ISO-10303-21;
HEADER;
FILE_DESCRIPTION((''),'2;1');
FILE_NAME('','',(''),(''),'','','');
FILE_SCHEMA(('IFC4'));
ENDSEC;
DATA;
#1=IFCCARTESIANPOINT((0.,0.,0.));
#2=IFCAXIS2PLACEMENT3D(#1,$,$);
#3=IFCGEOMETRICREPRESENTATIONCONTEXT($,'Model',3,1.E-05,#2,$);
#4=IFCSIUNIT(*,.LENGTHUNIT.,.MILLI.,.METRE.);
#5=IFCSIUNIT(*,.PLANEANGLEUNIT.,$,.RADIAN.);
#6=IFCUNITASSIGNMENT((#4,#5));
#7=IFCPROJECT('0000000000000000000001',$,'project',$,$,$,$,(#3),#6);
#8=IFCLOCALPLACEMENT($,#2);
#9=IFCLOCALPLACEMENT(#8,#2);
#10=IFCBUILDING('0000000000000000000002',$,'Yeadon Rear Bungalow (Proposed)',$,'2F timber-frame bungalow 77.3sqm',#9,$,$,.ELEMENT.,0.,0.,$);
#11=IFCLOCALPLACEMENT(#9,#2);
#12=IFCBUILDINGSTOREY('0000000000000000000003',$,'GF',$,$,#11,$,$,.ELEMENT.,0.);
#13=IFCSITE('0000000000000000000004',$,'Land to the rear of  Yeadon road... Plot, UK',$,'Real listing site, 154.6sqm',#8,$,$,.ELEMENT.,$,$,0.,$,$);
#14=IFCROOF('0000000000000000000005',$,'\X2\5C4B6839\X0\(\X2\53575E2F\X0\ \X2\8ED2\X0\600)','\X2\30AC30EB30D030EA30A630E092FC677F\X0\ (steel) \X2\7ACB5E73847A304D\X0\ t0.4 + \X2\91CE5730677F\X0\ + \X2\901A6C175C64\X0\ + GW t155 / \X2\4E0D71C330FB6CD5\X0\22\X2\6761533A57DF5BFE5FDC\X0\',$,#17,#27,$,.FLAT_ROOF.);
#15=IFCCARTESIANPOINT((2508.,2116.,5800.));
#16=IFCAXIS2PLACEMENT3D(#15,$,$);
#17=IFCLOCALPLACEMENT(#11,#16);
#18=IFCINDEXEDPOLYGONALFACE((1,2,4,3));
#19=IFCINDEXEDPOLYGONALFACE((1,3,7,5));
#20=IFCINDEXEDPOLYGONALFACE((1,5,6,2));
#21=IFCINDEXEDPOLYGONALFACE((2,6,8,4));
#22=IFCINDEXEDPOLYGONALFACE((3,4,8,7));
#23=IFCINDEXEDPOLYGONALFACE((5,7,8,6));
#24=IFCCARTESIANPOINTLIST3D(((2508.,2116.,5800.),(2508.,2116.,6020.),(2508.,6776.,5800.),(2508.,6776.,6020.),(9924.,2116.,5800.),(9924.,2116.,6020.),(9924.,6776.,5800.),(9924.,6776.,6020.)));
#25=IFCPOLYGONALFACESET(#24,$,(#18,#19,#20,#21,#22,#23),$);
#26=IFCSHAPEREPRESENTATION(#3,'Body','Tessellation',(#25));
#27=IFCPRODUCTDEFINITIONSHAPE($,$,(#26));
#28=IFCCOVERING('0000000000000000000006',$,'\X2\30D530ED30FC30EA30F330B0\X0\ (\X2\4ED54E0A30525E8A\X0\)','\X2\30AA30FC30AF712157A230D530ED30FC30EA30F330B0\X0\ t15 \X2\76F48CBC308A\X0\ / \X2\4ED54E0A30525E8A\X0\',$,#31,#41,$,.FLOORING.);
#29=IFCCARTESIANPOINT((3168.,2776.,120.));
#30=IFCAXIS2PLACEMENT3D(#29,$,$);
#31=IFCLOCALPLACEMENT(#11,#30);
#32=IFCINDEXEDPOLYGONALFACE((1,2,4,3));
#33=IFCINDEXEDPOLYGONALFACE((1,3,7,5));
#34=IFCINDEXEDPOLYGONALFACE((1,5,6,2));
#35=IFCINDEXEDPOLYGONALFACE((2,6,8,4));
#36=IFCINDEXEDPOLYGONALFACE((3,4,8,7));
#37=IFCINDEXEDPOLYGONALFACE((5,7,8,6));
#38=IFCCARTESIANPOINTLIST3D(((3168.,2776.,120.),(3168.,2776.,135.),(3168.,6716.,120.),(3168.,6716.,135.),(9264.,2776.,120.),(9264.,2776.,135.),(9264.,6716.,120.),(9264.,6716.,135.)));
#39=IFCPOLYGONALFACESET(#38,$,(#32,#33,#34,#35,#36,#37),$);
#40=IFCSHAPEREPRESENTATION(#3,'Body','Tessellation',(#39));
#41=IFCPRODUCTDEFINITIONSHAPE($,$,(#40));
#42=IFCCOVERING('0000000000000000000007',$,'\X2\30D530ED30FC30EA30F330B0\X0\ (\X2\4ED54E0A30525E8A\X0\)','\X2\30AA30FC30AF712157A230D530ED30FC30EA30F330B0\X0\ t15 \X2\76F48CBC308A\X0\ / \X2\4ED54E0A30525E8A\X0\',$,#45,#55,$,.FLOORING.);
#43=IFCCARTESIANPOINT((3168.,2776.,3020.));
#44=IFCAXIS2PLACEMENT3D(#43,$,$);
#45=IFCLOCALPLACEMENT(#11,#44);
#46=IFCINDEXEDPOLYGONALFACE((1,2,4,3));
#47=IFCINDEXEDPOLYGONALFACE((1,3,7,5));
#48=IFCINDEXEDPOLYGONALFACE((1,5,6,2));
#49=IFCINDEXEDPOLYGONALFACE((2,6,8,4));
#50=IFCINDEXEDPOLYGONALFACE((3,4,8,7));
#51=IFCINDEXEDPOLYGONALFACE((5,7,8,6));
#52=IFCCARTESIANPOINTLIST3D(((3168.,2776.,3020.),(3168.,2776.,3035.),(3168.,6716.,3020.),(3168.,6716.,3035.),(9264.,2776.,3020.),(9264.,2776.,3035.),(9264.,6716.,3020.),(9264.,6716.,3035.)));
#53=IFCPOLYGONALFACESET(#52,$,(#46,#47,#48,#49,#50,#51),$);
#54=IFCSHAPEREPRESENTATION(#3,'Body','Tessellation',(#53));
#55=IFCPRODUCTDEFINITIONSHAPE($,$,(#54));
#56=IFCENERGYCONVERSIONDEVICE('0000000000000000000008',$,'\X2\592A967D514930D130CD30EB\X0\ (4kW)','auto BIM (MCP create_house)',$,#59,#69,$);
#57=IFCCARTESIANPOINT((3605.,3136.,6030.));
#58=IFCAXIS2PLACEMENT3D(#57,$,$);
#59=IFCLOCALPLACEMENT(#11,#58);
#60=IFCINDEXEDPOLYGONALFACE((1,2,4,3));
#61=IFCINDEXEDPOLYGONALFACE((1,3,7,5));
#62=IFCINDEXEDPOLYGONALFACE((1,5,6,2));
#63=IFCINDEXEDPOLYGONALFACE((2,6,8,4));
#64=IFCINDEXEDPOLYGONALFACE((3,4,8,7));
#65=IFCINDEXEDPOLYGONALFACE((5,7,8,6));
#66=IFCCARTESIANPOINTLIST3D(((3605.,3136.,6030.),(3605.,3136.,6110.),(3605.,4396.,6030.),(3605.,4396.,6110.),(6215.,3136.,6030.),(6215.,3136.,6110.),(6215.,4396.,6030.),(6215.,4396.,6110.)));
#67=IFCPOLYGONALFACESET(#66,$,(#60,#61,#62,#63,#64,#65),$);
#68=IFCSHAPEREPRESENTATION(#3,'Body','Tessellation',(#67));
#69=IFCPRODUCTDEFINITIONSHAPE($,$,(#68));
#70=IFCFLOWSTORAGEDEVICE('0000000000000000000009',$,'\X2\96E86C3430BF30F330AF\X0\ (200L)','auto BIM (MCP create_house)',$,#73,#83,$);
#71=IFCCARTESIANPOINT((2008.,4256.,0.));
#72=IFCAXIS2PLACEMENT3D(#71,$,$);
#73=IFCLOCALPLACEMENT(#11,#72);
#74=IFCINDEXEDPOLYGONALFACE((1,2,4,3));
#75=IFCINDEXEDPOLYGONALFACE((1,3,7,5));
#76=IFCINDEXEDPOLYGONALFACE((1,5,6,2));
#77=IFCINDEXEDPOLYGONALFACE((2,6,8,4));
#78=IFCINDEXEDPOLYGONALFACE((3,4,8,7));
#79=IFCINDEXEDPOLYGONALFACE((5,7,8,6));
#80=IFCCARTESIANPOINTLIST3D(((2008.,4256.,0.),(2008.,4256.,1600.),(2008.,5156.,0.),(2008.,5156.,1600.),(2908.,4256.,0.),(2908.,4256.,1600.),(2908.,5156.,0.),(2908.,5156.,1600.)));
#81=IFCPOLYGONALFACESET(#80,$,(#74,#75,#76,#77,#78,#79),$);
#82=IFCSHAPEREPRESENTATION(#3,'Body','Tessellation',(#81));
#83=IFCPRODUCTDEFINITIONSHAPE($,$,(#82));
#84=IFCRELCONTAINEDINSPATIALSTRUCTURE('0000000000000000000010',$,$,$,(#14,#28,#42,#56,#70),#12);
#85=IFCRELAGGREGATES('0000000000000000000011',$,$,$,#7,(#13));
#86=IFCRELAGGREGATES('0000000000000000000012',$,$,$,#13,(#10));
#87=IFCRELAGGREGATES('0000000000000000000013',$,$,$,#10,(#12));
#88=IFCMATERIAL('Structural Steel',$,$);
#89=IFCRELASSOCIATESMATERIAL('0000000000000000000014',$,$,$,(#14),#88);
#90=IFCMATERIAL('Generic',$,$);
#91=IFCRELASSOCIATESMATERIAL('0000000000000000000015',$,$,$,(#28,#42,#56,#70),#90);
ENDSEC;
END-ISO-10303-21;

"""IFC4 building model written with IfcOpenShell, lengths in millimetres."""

from ifc_helpers import new_model, si_unit, frame, frame_2d, origin, place, context, project, spatial, rectangle, extrude, material, element, save


model = new_model("IFC4")

# Units and contexts
model_context = context("Model", 3, precision=1e-05, world=origin())
ifc_project = project(units=[si_unit("LENGTHUNIT", "METRE", prefix="MILLI"), si_unit("PLANEANGLEUNIT", "RADIAN")], contexts=[model_context])

# Site, building, storey
site_placement = place(None, origin())
site = spatial("IfcSite", under=ifc_project, at=site_placement, Name="Land to the rear of  Yeadon road... Plot, UK", ObjectType="Real listing site, 154.6sqm", CompositionType="ELEMENT", RefElevation=0.0)
building_placement = place(site_placement, origin())
building = spatial("IfcBuilding", under=site, at=building_placement, Name="Yeadon Rear Bungalow (Proposed)", ObjectType="2F timber-frame bungalow 77.3sqm", CompositionType="ELEMENT", ElevationOfRefHeight=0.0, ElevationOfTerrain=0.0)
storey_placement = place(building_placement, origin())
storey = spatial("IfcBuildingStorey", under=building, at=storey_placement, Name="GF", CompositionType="ELEMENT", Elevation=0.0)

# Roof
ifc_material_1 = material(Name="Structural Steel")
for number, where, name in (
    (1, (2508.0, 2116.0, 5800.0), "屋根(南帯 軒600)"),
):
    element("IfcRoof", number, at=place(storey_placement, frame(where)), inside=storey, material=ifc_material_1, Name=name, Description="ガルバリウム鋼板 (steel) 立平葺き t0.4 + 野地板 + 通気層 + GW t155 / 不燃・法22条区域対応", PredefinedType="FLAT_ROOF", context=model_context, shape_type="SweptSolid", body=[
        extrude(rectangle(XDim=7416.0, YDim=4660.0, at=frame_2d((3708.0, 2330.0))), frame((2508.0, 2116.0, 5800.0)), (0.0, 0.0, 1.0), 220.0),
    ])

# Coverings
ifc_material_2 = material(Name="Generic")
covering_1_placement = place(storey_placement, frame((3168.0, 2776.0, 120.0)))
element("IfcCovering", 2, at=covering_1_placement, inside=storey, material=ifc_material_2, Name="フローリング (仕上げ床)", Description="オーク無垢フローリング t15 直貼り / 仕上げ床", PredefinedType="FLOORING", context=model_context, shape_type="SweptSolid", body=[
    extrude(rectangle(XDim=6096.0, YDim=3940.0, at=frame_2d((3048.0, 1970.0))), frame((3168.0, 2776.0, 120.0)), (0.0, 0.0, 1.0), 15.0),
])
covering_2_placement = place(storey_placement, frame((3168.0, 2776.0, 3020.0)))
element("IfcCovering", 3, at=covering_2_placement, inside=storey, material=ifc_material_2, Name="フローリング (仕上げ床)", Description="オーク無垢フローリング t15 直貼り / 仕上げ床", PredefinedType="FLOORING", context=model_context, shape_type="SweptSolid", body=[
    extrude(rectangle(XDim=6096.0, YDim=3940.0, at=frame_2d((3048.0, 1970.0))), frame((3168.0, 2776.0, 3020.0)), (0.0, 0.0, 1.0), 15.0),
])

# Energy conversion device
energy_conversion_device_placement = place(storey_placement, frame((3605.0, 3136.0, 6030.0)))
element("IfcEnergyConversionDevice", 4, at=energy_conversion_device_placement, inside=storey, material=ifc_material_2, Name="太陽光パネル (4kW)", Description="auto BIM (MCP create_house)", context=model_context, shape_type="SweptSolid", body=[
    extrude(rectangle(XDim=2610.0, YDim=1260.0, at=frame_2d((1305.0, 630.0))), frame((3605.0, 3136.0, 6030.0)), (0.0, 0.0, 1.0), 80.0),
])

# Flow storage device
flow_storage_device_placement = place(storey_placement, frame((2008.0, 4256.0, 0.0)))
element("IfcFlowStorageDevice", 5, at=flow_storage_device_placement, inside=storey, material=ifc_material_2, Name="雨水タンク (200L)", Description="auto BIM (MCP create_house)", context=model_context, shape_type="SweptSolid", body=[
    extrude(rectangle(XDim=900.0, YDim=900.0, at=frame_2d((450.0, 450.0))), frame((2008.0, 4256.0, 0.0)), (0.0, 0.0, 1.0), 1600.0),
])

save(model, "model.ifc")
